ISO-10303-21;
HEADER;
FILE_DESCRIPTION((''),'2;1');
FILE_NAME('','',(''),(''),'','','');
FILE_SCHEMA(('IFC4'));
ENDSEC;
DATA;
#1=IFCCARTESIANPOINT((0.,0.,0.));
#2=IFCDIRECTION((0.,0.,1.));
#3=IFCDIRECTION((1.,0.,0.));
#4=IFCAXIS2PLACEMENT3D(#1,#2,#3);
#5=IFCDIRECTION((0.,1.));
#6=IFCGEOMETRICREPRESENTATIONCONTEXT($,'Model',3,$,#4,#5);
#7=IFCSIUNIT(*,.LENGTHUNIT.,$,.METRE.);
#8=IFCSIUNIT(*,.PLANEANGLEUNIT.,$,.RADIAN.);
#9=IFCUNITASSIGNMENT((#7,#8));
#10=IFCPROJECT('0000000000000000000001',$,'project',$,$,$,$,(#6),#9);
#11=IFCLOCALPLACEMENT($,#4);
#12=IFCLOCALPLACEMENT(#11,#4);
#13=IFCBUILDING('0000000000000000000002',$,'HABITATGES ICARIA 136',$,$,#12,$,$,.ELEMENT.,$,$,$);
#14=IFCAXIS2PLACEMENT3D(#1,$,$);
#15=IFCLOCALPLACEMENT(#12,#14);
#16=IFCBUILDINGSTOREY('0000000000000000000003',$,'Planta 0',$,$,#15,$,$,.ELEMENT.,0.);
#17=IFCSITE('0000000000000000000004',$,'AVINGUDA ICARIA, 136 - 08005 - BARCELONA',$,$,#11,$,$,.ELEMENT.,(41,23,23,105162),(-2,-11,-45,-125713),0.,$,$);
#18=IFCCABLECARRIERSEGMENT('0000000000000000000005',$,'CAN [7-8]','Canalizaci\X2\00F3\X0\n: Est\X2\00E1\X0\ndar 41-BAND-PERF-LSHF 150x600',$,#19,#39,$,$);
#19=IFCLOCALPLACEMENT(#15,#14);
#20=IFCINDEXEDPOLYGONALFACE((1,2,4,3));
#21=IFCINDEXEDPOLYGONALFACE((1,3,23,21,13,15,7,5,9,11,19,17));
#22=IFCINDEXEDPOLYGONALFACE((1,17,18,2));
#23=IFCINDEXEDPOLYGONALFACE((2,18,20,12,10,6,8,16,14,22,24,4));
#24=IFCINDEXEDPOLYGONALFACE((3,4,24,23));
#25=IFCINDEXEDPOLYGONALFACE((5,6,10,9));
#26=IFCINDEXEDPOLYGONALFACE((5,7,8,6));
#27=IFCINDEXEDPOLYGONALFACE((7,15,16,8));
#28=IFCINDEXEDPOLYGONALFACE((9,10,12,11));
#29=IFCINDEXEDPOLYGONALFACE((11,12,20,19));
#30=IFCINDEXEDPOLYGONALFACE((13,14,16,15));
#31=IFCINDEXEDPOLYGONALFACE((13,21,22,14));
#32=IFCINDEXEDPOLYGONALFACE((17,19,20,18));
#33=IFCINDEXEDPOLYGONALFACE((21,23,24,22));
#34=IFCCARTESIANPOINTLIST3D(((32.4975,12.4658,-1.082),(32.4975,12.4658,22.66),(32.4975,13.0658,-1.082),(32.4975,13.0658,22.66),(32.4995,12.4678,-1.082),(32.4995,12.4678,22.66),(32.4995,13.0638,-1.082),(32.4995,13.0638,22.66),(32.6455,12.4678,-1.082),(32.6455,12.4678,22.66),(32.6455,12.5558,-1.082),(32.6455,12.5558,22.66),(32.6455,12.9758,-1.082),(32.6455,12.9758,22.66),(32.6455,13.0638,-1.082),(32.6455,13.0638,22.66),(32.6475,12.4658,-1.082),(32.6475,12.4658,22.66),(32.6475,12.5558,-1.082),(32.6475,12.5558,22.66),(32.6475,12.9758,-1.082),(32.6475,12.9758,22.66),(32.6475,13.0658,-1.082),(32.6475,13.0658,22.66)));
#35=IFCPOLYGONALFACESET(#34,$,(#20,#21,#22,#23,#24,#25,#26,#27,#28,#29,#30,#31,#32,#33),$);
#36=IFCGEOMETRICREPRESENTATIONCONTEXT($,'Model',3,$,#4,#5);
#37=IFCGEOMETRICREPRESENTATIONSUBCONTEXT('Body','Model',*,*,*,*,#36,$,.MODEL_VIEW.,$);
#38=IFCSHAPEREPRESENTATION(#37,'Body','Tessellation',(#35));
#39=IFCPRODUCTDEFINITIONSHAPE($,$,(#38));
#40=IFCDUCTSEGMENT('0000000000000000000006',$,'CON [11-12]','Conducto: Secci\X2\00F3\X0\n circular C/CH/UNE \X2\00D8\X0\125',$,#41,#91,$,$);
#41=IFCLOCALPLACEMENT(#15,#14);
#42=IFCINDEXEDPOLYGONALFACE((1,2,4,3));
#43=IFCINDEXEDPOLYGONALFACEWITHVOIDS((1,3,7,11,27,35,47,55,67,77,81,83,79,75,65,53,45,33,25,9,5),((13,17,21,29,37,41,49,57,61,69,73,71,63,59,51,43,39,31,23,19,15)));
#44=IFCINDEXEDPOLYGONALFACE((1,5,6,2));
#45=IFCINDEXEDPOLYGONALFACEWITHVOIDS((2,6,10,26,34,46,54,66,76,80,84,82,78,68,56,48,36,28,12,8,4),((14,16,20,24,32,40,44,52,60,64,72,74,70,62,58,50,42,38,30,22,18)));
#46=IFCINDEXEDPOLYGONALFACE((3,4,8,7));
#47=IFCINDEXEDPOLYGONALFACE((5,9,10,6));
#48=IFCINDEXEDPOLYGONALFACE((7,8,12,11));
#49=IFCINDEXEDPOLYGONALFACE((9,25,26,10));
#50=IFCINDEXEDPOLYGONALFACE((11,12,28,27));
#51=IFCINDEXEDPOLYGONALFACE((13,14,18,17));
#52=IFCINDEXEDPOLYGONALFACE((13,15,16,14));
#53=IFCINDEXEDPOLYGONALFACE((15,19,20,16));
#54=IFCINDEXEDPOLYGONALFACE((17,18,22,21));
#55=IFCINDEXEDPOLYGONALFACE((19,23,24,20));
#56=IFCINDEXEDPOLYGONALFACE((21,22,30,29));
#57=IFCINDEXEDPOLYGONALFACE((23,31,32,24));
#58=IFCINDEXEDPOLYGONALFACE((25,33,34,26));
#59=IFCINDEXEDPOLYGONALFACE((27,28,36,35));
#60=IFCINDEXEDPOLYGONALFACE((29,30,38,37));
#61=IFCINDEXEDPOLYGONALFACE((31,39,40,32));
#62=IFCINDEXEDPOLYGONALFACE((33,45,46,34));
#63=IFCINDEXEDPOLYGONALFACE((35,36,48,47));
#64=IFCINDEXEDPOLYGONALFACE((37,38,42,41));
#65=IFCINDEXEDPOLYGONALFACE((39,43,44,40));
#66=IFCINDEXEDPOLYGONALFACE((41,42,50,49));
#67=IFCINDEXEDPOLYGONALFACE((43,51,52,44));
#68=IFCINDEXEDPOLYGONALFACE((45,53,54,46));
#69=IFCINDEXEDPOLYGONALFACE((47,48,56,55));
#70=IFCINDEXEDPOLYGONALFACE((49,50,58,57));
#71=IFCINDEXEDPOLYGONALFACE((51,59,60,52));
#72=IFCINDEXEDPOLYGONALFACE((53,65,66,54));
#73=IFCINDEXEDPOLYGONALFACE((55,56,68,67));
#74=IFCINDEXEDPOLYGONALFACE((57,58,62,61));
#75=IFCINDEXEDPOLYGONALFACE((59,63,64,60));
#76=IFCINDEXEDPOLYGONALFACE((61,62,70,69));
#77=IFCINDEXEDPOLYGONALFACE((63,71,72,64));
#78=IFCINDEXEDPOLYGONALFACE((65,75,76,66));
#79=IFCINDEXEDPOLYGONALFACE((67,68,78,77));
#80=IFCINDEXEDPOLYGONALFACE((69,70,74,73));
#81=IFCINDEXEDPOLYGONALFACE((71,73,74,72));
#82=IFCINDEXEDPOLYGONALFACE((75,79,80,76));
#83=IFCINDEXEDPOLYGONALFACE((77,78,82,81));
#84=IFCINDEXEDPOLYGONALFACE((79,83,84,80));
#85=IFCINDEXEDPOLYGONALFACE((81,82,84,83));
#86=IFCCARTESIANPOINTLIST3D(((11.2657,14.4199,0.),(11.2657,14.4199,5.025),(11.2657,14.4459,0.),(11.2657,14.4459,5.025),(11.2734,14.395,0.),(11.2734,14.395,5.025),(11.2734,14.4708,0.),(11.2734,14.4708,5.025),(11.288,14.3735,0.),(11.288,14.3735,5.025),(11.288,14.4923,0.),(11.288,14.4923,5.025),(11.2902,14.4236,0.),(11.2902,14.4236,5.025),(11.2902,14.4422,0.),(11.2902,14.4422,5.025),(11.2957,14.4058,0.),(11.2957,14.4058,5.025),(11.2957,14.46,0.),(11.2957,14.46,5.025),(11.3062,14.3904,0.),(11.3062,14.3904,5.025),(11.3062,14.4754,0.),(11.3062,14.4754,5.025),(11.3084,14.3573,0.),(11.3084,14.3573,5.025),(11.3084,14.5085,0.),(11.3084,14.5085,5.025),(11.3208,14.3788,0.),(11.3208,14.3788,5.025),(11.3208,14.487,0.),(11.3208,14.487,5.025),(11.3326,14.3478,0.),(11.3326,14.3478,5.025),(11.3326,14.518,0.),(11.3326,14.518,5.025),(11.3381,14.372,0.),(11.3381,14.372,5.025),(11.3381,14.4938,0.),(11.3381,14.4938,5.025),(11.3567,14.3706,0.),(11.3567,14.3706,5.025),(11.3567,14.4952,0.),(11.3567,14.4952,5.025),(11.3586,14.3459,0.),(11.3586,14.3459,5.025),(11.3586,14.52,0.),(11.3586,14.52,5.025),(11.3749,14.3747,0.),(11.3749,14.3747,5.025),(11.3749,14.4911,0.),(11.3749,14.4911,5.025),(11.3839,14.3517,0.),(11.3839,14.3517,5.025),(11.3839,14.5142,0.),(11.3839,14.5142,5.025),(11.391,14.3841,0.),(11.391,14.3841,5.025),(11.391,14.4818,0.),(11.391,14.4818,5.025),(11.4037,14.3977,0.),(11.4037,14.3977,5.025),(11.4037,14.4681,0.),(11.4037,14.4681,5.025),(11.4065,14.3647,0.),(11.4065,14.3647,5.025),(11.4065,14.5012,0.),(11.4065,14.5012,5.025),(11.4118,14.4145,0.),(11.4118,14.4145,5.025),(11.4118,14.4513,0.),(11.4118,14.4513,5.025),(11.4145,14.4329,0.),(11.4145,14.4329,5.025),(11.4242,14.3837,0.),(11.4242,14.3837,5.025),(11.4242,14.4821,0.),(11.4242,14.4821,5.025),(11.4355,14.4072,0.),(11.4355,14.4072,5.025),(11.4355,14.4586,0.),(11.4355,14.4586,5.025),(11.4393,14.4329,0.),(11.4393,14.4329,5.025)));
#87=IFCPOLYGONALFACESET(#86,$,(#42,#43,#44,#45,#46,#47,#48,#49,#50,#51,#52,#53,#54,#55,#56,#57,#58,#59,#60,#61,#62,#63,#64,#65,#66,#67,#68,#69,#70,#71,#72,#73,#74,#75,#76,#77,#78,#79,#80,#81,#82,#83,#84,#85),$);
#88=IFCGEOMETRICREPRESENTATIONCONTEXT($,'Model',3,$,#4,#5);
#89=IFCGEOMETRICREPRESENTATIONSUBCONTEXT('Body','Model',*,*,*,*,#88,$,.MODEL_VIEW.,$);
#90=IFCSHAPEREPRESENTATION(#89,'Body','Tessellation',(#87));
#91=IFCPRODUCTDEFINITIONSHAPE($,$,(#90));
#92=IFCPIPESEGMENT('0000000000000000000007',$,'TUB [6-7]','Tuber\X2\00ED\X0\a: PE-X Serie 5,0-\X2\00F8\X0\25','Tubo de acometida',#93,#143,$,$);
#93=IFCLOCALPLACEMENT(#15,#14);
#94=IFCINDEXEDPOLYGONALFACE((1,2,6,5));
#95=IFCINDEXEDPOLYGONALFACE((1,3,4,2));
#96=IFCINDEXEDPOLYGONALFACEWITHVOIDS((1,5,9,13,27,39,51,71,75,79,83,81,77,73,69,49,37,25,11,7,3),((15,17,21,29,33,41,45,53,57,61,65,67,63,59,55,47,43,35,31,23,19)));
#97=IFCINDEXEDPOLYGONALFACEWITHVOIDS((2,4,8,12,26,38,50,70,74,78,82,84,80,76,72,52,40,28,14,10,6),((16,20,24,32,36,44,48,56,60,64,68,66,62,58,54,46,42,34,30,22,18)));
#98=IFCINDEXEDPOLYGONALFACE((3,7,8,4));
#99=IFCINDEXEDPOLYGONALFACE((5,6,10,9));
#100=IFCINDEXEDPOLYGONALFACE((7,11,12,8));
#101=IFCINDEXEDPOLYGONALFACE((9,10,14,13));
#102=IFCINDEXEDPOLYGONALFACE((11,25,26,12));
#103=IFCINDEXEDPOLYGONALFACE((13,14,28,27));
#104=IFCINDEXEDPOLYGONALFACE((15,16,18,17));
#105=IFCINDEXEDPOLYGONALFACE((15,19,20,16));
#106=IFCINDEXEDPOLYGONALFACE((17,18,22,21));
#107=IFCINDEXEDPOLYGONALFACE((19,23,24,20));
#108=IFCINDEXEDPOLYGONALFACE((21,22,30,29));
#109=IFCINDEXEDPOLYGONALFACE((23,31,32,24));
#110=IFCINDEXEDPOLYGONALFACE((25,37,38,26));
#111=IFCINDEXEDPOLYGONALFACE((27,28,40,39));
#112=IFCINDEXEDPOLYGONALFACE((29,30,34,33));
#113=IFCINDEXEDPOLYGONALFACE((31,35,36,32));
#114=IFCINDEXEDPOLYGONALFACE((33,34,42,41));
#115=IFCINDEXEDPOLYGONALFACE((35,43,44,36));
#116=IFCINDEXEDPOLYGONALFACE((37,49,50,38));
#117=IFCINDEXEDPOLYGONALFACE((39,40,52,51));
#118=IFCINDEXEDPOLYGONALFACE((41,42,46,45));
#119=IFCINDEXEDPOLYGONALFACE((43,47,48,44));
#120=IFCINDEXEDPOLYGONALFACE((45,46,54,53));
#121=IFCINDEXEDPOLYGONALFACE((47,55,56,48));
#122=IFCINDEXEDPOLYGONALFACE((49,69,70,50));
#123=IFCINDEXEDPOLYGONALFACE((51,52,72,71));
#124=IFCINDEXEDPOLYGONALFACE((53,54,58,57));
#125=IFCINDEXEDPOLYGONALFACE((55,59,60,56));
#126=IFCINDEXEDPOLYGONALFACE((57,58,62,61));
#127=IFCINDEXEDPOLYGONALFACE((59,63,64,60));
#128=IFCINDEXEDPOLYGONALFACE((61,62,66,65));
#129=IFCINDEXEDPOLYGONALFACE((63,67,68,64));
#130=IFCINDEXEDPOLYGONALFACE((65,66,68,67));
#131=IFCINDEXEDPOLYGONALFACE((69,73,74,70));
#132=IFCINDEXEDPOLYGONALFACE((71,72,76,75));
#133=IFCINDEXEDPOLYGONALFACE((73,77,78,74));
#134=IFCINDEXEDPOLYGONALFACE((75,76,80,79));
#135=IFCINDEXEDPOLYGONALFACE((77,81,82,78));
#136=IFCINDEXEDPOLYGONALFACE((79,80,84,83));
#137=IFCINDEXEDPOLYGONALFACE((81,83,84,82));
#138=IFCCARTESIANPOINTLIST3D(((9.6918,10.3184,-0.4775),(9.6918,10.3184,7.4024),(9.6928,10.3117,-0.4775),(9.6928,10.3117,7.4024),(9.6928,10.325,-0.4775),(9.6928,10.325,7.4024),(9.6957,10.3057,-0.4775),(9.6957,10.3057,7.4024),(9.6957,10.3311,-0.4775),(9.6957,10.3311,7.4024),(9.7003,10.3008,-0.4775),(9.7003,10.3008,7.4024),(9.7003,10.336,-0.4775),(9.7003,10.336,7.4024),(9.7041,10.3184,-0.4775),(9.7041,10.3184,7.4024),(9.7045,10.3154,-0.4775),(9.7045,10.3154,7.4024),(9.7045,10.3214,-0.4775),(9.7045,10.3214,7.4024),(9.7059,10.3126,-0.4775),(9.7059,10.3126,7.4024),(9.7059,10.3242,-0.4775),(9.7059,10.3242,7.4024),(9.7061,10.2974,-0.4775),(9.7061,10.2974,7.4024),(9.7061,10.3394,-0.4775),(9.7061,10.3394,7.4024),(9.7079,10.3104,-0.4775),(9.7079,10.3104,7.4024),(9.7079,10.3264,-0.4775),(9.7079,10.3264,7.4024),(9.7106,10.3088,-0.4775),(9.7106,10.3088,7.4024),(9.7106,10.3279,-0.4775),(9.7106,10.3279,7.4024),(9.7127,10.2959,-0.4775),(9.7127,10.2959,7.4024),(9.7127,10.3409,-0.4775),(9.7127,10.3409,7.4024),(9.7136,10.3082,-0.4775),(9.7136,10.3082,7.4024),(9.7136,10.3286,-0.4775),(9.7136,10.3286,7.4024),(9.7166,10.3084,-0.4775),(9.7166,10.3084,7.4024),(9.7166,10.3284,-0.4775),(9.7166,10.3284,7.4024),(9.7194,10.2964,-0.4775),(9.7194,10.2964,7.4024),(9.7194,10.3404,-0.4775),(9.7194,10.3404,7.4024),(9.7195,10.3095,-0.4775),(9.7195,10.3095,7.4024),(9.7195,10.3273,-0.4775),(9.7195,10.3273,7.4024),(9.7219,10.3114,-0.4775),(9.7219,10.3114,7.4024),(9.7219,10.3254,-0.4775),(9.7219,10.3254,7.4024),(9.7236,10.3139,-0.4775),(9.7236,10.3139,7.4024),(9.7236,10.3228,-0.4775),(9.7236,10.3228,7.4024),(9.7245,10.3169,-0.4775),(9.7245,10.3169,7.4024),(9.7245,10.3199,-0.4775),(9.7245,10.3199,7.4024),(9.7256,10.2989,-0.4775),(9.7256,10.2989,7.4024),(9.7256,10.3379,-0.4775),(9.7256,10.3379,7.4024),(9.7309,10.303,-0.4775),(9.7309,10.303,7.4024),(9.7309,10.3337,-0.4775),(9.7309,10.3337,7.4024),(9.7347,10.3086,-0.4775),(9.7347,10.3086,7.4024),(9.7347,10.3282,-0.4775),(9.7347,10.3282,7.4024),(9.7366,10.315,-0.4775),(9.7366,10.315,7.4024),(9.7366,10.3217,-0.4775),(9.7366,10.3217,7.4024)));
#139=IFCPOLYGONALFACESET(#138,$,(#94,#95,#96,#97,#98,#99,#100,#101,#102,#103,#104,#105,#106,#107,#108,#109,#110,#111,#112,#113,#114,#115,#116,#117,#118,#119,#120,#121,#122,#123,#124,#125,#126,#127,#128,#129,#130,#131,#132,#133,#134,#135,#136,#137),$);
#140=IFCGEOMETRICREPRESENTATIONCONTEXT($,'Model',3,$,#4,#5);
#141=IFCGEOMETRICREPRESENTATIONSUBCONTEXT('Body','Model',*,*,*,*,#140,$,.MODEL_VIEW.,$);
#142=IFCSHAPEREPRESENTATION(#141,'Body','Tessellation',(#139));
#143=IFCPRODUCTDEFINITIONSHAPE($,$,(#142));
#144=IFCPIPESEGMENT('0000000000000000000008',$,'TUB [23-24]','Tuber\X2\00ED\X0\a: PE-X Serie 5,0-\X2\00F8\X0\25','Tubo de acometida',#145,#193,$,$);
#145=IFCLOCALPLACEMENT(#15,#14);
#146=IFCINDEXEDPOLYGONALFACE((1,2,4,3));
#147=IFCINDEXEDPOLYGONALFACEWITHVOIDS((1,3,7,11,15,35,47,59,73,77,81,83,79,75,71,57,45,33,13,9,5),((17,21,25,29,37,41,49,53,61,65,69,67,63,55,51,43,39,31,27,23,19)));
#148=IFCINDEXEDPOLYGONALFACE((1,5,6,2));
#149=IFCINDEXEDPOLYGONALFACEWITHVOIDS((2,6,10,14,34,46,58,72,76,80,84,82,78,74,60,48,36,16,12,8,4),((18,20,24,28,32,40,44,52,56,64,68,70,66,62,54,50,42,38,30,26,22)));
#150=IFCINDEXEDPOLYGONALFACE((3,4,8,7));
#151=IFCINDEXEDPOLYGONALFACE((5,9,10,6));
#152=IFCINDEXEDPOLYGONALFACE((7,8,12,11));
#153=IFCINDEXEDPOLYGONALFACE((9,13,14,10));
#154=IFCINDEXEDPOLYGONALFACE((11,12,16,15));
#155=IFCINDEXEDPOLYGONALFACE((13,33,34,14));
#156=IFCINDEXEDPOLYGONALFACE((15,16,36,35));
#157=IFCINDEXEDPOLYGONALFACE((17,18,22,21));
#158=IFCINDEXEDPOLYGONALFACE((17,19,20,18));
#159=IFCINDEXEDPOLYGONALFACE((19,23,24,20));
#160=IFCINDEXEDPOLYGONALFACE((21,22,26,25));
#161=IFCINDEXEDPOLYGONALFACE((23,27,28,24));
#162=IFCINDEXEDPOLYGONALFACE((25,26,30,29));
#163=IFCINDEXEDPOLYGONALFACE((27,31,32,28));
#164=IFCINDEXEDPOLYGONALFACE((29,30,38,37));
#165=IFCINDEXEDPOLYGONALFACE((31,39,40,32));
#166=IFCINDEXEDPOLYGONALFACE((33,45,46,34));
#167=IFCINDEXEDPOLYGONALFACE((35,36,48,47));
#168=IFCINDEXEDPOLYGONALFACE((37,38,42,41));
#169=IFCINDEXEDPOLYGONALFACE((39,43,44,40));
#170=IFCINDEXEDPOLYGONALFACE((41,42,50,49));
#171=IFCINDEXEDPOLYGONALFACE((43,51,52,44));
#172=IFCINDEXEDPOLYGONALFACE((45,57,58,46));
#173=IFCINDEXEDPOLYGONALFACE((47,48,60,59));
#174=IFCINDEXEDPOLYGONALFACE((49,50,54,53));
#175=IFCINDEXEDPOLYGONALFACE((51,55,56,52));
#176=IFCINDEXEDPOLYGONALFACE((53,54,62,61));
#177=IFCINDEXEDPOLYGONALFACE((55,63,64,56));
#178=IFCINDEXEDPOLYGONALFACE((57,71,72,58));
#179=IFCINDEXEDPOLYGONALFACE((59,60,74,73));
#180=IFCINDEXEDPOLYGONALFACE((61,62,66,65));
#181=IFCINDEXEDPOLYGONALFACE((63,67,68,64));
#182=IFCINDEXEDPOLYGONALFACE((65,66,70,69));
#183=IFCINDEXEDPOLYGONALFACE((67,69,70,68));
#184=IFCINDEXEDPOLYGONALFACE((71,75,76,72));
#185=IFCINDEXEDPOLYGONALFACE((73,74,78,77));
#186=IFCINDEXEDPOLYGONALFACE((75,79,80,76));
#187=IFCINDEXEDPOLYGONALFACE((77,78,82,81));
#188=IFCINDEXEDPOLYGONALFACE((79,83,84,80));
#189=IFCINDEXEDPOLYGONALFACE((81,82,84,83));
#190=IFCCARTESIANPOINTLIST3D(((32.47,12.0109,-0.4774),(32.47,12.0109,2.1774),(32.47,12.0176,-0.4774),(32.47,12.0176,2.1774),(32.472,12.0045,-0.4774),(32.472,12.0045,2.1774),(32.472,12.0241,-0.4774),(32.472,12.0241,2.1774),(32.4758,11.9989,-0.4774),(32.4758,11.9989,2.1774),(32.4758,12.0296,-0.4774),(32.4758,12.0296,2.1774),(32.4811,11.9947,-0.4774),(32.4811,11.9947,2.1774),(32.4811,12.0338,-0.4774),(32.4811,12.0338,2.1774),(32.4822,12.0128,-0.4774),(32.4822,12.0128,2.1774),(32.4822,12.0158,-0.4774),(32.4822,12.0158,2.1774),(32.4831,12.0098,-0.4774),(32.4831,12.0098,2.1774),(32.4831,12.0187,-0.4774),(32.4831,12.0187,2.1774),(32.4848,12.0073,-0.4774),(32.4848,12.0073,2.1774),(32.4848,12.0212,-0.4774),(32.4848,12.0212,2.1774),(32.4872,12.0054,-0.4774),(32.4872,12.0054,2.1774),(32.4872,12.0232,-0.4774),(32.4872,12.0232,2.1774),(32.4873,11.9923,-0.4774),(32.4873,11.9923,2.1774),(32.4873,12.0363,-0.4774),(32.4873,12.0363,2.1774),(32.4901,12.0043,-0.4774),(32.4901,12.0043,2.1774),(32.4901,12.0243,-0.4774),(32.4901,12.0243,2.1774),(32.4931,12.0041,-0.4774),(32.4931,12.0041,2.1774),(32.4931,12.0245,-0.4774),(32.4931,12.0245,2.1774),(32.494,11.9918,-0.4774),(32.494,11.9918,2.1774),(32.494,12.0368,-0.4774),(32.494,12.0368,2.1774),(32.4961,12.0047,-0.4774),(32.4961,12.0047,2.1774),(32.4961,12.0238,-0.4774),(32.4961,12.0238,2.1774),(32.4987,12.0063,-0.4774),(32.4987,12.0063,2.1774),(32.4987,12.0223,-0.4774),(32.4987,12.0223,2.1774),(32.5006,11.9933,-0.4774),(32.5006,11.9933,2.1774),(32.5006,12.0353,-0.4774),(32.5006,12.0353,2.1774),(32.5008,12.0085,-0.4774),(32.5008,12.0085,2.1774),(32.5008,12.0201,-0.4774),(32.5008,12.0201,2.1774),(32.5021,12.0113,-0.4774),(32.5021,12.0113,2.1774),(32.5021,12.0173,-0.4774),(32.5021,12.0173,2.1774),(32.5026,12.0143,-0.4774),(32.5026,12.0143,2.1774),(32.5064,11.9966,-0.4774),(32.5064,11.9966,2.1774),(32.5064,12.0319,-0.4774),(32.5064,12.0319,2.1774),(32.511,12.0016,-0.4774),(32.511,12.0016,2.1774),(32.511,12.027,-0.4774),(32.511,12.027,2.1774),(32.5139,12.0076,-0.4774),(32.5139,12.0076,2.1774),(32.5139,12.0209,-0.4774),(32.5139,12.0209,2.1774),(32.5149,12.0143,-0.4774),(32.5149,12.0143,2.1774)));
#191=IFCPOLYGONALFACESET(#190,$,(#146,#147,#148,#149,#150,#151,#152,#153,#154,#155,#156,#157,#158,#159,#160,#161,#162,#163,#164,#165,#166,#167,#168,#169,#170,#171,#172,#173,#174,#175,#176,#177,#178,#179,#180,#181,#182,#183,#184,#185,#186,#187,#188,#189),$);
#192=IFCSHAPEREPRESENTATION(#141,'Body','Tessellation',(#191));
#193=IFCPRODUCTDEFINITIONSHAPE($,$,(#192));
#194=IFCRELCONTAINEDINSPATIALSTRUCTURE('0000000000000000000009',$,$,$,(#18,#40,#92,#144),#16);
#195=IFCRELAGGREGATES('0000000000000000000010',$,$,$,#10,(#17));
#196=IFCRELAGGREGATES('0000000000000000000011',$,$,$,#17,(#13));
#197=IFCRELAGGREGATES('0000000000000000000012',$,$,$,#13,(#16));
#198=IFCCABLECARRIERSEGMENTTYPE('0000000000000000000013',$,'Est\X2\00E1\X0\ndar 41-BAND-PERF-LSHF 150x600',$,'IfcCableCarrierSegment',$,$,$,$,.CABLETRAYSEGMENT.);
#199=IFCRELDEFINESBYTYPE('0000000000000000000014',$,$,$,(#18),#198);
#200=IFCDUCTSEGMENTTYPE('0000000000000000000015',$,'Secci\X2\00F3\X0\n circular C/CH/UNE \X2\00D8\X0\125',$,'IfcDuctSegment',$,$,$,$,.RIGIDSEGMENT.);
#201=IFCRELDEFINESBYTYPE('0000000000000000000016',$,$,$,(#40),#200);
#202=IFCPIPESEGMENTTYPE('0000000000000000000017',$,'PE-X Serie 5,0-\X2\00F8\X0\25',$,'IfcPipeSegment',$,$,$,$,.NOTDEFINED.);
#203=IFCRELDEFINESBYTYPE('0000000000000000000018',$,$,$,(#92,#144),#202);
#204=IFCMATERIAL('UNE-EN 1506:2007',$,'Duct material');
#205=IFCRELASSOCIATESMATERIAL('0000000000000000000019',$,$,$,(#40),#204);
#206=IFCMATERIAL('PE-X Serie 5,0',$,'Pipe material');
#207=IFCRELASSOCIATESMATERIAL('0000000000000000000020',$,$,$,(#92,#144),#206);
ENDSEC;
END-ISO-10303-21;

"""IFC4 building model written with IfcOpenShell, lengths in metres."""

from ifc_helpers import new_model, si_unit, direction, frame, origin, origin_with_axes, origin_2d_with_axis, place, context, subcontext, project, spatial, polyline, hollow_circle, outline, extrude, material, type_object, element, save


model = new_model("IFC4")

# Units and contexts
model_context_1 = context("Model", 3, world=origin_with_axes(), true_north=direction((0.0, 1.0)))
model_context_2 = context("Model", 3, world=origin_with_axes(), true_north=direction((0.0, 1.0)))
model_context_3 = context("Model", 3, world=origin_with_axes(), true_north=direction((0.0, 1.0)))
model_context_4 = context("Model", 3, world=origin_with_axes(), true_north=direction((0.0, 1.0)))
body_context_1 = subcontext(model_context_2, "Body", "Model", "MODEL_VIEW")
body_context_2 = subcontext(model_context_3, "Body", "Model", "MODEL_VIEW")
body_context_3 = subcontext(model_context_4, "Body", "Model", "MODEL_VIEW")
ifc_project = project(units=[si_unit("LENGTHUNIT", "METRE"), si_unit("PLANEANGLEUNIT", "RADIAN")], contexts=[model_context_1])

# Site, building, storey
site_placement = place(None, origin_with_axes())
site = spatial("IfcSite", under=ifc_project, at=site_placement, Name="AVINGUDA ICARIA, 136 - 08005 - BARCELONA", CompositionType="ELEMENT", RefLatitude=(41, 23, 23, 105162), RefLongitude=(-2, -11, -45, -125713), RefElevation=0.0)
building_placement = place(site_placement, origin_with_axes())
building = spatial("IfcBuilding", under=site, at=building_placement, Name="HABITATGES ICARIA 136", CompositionType="ELEMENT")
storey_placement = place(building_placement, origin())
storey = spatial("IfcBuildingStorey", under=building, at=storey_placement, Name="Planta 0", CompositionType="ELEMENT", Elevation=0.0)

# Cable carrier segment
cable_carrier_segment_type = type_object("IfcCableCarrierSegmentType", Name="Estándar 41-BAND-PERF-LSHF 150x600", ApplicableOccurrence="IfcCableCarrierSegment", PredefinedType="CABLETRAYSEGMENT")
placement_1 = place(None, origin_with_axes())
placement_2 = place(placement_1, origin_with_axes())
placement_3 = place(placement_2, origin())
cable_carrier_segment_placement = place(placement_3, origin_with_axes())
element("IfcCableCarrierSegment", 1, at=cable_carrier_segment_placement, inside=storey, type_object=cable_carrier_segment_type, Name="CAN [7-8]", Description="Canalización: Estándar 41-BAND-PERF-LSHF 150x600", context=body_context_1, shape_type="SweptSolid", body=[
    extrude(outline(polyline([(-0.21, 0.148), (-0.21, 0.15), (-0.3, 0.15), (-0.3, 0.0), (0.3, 0.0), (0.3, 0.15), (0.21, 0.15), (0.21, 0.148), (0.298, 0.148), (0.298, 0.002), (-0.298, 0.002), (-0.298, 0.148), (-0.21, 0.148)])), frame((32.4975, 12.7658, -1.082), z_axis=(0.0, 0.0, 1.0), x_axis=(0.0, -1.0, 0.0)), (0.0, 0.0, 1.0), 23.742),
])

# Duct segment
ifc_material_1 = material(Name="UNE-EN 1506:2007", Category="Duct material")
duct_segment_type = type_object("IfcDuctSegmentType", Name="Sección circular C/CH/UNE Ø125", ApplicableOccurrence="IfcDuctSegment", PredefinedType="RIGIDSEGMENT")
placement_4 = place(None, origin_with_axes())
placement_5 = place(placement_4, origin_with_axes())
placement_6 = place(placement_5, origin())
duct_segment_placement = place(placement_6, origin_with_axes())
element("IfcDuctSegment", 2, at=duct_segment_placement, inside=storey, type_object=duct_segment_type, material=ifc_material_1, Name="CON [11-12]", Description="Conducto: Sección circular C/CH/UNE Ø125", context=body_context_2, shape_type="SweptSolid", body=[
    extrude(hollow_circle(Radius=0.0873, WallThickness=0.0248, at=origin_2d_with_axis()), frame((11.352, 14.4329, 5.025), z_axis=(0.0, 0.0, -1.0), x_axis=(1.0, 0.0, 0.0)), (0.0, 0.0, 1.0), 5.025),
])

# Pipe segments
ifc_material_2 = material(Name="PE-X Serie 5,0", Category="Pipe material")
pipe_segment_type = type_object("IfcPipeSegmentType", Name="PE-X Serie 5,0-ø25", ApplicableOccurrence="IfcPipeSegment", PredefinedType="NOTDEFINED")
placement_7 = place(None, origin_with_axes())
placement_8 = place(placement_7, origin_with_axes())
placement_9 = place(placement_8, origin())
pipe_segment_1_placement = place(placement_9, origin_with_axes())
element("IfcPipeSegment", 3, at=pipe_segment_1_placement, inside=storey, type_object=pipe_segment_type, material=ifc_material_2, Name="TUB [6-7]", Description="Tubería: PE-X Serie 5,0-ø25", ObjectType="Tubo de acometida", context=body_context_3, shape_type="SweptSolid", body=[
    extrude(hollow_circle(Radius=0.0226, WallThickness=0.0123, at=origin_2d_with_axis()), frame((9.7143, 10.3184, 7.4024), z_axis=(0.0, 0.0, -1.0), x_axis=(-1.0, 0.0, 0.0)), (0.0, 0.0, 1.0), 7.8799),
])
pipe_segment_2_placement = place(placement_9, origin_with_axes())
element("IfcPipeSegment", 4, at=pipe_segment_2_placement, inside=storey, type_object=pipe_segment_type, material=ifc_material_2, Name="TUB [23-24]", Description="Tubería: PE-X Serie 5,0-ø25", ObjectType="Tubo de acometida", context=body_context_3, shape_type="SweptSolid", body=[
    extrude(hollow_circle(Radius=0.0226, WallThickness=0.0123, at=origin_2d_with_axis()), frame((32.4923, 12.0143, -0.4774), z_axis=(0.0, 0.0, 1.0), x_axis=(1.0, 0.0, 0.0)), (0.0, 0.0, 1.0), 2.6549),
])

save(model, "model.ifc")
